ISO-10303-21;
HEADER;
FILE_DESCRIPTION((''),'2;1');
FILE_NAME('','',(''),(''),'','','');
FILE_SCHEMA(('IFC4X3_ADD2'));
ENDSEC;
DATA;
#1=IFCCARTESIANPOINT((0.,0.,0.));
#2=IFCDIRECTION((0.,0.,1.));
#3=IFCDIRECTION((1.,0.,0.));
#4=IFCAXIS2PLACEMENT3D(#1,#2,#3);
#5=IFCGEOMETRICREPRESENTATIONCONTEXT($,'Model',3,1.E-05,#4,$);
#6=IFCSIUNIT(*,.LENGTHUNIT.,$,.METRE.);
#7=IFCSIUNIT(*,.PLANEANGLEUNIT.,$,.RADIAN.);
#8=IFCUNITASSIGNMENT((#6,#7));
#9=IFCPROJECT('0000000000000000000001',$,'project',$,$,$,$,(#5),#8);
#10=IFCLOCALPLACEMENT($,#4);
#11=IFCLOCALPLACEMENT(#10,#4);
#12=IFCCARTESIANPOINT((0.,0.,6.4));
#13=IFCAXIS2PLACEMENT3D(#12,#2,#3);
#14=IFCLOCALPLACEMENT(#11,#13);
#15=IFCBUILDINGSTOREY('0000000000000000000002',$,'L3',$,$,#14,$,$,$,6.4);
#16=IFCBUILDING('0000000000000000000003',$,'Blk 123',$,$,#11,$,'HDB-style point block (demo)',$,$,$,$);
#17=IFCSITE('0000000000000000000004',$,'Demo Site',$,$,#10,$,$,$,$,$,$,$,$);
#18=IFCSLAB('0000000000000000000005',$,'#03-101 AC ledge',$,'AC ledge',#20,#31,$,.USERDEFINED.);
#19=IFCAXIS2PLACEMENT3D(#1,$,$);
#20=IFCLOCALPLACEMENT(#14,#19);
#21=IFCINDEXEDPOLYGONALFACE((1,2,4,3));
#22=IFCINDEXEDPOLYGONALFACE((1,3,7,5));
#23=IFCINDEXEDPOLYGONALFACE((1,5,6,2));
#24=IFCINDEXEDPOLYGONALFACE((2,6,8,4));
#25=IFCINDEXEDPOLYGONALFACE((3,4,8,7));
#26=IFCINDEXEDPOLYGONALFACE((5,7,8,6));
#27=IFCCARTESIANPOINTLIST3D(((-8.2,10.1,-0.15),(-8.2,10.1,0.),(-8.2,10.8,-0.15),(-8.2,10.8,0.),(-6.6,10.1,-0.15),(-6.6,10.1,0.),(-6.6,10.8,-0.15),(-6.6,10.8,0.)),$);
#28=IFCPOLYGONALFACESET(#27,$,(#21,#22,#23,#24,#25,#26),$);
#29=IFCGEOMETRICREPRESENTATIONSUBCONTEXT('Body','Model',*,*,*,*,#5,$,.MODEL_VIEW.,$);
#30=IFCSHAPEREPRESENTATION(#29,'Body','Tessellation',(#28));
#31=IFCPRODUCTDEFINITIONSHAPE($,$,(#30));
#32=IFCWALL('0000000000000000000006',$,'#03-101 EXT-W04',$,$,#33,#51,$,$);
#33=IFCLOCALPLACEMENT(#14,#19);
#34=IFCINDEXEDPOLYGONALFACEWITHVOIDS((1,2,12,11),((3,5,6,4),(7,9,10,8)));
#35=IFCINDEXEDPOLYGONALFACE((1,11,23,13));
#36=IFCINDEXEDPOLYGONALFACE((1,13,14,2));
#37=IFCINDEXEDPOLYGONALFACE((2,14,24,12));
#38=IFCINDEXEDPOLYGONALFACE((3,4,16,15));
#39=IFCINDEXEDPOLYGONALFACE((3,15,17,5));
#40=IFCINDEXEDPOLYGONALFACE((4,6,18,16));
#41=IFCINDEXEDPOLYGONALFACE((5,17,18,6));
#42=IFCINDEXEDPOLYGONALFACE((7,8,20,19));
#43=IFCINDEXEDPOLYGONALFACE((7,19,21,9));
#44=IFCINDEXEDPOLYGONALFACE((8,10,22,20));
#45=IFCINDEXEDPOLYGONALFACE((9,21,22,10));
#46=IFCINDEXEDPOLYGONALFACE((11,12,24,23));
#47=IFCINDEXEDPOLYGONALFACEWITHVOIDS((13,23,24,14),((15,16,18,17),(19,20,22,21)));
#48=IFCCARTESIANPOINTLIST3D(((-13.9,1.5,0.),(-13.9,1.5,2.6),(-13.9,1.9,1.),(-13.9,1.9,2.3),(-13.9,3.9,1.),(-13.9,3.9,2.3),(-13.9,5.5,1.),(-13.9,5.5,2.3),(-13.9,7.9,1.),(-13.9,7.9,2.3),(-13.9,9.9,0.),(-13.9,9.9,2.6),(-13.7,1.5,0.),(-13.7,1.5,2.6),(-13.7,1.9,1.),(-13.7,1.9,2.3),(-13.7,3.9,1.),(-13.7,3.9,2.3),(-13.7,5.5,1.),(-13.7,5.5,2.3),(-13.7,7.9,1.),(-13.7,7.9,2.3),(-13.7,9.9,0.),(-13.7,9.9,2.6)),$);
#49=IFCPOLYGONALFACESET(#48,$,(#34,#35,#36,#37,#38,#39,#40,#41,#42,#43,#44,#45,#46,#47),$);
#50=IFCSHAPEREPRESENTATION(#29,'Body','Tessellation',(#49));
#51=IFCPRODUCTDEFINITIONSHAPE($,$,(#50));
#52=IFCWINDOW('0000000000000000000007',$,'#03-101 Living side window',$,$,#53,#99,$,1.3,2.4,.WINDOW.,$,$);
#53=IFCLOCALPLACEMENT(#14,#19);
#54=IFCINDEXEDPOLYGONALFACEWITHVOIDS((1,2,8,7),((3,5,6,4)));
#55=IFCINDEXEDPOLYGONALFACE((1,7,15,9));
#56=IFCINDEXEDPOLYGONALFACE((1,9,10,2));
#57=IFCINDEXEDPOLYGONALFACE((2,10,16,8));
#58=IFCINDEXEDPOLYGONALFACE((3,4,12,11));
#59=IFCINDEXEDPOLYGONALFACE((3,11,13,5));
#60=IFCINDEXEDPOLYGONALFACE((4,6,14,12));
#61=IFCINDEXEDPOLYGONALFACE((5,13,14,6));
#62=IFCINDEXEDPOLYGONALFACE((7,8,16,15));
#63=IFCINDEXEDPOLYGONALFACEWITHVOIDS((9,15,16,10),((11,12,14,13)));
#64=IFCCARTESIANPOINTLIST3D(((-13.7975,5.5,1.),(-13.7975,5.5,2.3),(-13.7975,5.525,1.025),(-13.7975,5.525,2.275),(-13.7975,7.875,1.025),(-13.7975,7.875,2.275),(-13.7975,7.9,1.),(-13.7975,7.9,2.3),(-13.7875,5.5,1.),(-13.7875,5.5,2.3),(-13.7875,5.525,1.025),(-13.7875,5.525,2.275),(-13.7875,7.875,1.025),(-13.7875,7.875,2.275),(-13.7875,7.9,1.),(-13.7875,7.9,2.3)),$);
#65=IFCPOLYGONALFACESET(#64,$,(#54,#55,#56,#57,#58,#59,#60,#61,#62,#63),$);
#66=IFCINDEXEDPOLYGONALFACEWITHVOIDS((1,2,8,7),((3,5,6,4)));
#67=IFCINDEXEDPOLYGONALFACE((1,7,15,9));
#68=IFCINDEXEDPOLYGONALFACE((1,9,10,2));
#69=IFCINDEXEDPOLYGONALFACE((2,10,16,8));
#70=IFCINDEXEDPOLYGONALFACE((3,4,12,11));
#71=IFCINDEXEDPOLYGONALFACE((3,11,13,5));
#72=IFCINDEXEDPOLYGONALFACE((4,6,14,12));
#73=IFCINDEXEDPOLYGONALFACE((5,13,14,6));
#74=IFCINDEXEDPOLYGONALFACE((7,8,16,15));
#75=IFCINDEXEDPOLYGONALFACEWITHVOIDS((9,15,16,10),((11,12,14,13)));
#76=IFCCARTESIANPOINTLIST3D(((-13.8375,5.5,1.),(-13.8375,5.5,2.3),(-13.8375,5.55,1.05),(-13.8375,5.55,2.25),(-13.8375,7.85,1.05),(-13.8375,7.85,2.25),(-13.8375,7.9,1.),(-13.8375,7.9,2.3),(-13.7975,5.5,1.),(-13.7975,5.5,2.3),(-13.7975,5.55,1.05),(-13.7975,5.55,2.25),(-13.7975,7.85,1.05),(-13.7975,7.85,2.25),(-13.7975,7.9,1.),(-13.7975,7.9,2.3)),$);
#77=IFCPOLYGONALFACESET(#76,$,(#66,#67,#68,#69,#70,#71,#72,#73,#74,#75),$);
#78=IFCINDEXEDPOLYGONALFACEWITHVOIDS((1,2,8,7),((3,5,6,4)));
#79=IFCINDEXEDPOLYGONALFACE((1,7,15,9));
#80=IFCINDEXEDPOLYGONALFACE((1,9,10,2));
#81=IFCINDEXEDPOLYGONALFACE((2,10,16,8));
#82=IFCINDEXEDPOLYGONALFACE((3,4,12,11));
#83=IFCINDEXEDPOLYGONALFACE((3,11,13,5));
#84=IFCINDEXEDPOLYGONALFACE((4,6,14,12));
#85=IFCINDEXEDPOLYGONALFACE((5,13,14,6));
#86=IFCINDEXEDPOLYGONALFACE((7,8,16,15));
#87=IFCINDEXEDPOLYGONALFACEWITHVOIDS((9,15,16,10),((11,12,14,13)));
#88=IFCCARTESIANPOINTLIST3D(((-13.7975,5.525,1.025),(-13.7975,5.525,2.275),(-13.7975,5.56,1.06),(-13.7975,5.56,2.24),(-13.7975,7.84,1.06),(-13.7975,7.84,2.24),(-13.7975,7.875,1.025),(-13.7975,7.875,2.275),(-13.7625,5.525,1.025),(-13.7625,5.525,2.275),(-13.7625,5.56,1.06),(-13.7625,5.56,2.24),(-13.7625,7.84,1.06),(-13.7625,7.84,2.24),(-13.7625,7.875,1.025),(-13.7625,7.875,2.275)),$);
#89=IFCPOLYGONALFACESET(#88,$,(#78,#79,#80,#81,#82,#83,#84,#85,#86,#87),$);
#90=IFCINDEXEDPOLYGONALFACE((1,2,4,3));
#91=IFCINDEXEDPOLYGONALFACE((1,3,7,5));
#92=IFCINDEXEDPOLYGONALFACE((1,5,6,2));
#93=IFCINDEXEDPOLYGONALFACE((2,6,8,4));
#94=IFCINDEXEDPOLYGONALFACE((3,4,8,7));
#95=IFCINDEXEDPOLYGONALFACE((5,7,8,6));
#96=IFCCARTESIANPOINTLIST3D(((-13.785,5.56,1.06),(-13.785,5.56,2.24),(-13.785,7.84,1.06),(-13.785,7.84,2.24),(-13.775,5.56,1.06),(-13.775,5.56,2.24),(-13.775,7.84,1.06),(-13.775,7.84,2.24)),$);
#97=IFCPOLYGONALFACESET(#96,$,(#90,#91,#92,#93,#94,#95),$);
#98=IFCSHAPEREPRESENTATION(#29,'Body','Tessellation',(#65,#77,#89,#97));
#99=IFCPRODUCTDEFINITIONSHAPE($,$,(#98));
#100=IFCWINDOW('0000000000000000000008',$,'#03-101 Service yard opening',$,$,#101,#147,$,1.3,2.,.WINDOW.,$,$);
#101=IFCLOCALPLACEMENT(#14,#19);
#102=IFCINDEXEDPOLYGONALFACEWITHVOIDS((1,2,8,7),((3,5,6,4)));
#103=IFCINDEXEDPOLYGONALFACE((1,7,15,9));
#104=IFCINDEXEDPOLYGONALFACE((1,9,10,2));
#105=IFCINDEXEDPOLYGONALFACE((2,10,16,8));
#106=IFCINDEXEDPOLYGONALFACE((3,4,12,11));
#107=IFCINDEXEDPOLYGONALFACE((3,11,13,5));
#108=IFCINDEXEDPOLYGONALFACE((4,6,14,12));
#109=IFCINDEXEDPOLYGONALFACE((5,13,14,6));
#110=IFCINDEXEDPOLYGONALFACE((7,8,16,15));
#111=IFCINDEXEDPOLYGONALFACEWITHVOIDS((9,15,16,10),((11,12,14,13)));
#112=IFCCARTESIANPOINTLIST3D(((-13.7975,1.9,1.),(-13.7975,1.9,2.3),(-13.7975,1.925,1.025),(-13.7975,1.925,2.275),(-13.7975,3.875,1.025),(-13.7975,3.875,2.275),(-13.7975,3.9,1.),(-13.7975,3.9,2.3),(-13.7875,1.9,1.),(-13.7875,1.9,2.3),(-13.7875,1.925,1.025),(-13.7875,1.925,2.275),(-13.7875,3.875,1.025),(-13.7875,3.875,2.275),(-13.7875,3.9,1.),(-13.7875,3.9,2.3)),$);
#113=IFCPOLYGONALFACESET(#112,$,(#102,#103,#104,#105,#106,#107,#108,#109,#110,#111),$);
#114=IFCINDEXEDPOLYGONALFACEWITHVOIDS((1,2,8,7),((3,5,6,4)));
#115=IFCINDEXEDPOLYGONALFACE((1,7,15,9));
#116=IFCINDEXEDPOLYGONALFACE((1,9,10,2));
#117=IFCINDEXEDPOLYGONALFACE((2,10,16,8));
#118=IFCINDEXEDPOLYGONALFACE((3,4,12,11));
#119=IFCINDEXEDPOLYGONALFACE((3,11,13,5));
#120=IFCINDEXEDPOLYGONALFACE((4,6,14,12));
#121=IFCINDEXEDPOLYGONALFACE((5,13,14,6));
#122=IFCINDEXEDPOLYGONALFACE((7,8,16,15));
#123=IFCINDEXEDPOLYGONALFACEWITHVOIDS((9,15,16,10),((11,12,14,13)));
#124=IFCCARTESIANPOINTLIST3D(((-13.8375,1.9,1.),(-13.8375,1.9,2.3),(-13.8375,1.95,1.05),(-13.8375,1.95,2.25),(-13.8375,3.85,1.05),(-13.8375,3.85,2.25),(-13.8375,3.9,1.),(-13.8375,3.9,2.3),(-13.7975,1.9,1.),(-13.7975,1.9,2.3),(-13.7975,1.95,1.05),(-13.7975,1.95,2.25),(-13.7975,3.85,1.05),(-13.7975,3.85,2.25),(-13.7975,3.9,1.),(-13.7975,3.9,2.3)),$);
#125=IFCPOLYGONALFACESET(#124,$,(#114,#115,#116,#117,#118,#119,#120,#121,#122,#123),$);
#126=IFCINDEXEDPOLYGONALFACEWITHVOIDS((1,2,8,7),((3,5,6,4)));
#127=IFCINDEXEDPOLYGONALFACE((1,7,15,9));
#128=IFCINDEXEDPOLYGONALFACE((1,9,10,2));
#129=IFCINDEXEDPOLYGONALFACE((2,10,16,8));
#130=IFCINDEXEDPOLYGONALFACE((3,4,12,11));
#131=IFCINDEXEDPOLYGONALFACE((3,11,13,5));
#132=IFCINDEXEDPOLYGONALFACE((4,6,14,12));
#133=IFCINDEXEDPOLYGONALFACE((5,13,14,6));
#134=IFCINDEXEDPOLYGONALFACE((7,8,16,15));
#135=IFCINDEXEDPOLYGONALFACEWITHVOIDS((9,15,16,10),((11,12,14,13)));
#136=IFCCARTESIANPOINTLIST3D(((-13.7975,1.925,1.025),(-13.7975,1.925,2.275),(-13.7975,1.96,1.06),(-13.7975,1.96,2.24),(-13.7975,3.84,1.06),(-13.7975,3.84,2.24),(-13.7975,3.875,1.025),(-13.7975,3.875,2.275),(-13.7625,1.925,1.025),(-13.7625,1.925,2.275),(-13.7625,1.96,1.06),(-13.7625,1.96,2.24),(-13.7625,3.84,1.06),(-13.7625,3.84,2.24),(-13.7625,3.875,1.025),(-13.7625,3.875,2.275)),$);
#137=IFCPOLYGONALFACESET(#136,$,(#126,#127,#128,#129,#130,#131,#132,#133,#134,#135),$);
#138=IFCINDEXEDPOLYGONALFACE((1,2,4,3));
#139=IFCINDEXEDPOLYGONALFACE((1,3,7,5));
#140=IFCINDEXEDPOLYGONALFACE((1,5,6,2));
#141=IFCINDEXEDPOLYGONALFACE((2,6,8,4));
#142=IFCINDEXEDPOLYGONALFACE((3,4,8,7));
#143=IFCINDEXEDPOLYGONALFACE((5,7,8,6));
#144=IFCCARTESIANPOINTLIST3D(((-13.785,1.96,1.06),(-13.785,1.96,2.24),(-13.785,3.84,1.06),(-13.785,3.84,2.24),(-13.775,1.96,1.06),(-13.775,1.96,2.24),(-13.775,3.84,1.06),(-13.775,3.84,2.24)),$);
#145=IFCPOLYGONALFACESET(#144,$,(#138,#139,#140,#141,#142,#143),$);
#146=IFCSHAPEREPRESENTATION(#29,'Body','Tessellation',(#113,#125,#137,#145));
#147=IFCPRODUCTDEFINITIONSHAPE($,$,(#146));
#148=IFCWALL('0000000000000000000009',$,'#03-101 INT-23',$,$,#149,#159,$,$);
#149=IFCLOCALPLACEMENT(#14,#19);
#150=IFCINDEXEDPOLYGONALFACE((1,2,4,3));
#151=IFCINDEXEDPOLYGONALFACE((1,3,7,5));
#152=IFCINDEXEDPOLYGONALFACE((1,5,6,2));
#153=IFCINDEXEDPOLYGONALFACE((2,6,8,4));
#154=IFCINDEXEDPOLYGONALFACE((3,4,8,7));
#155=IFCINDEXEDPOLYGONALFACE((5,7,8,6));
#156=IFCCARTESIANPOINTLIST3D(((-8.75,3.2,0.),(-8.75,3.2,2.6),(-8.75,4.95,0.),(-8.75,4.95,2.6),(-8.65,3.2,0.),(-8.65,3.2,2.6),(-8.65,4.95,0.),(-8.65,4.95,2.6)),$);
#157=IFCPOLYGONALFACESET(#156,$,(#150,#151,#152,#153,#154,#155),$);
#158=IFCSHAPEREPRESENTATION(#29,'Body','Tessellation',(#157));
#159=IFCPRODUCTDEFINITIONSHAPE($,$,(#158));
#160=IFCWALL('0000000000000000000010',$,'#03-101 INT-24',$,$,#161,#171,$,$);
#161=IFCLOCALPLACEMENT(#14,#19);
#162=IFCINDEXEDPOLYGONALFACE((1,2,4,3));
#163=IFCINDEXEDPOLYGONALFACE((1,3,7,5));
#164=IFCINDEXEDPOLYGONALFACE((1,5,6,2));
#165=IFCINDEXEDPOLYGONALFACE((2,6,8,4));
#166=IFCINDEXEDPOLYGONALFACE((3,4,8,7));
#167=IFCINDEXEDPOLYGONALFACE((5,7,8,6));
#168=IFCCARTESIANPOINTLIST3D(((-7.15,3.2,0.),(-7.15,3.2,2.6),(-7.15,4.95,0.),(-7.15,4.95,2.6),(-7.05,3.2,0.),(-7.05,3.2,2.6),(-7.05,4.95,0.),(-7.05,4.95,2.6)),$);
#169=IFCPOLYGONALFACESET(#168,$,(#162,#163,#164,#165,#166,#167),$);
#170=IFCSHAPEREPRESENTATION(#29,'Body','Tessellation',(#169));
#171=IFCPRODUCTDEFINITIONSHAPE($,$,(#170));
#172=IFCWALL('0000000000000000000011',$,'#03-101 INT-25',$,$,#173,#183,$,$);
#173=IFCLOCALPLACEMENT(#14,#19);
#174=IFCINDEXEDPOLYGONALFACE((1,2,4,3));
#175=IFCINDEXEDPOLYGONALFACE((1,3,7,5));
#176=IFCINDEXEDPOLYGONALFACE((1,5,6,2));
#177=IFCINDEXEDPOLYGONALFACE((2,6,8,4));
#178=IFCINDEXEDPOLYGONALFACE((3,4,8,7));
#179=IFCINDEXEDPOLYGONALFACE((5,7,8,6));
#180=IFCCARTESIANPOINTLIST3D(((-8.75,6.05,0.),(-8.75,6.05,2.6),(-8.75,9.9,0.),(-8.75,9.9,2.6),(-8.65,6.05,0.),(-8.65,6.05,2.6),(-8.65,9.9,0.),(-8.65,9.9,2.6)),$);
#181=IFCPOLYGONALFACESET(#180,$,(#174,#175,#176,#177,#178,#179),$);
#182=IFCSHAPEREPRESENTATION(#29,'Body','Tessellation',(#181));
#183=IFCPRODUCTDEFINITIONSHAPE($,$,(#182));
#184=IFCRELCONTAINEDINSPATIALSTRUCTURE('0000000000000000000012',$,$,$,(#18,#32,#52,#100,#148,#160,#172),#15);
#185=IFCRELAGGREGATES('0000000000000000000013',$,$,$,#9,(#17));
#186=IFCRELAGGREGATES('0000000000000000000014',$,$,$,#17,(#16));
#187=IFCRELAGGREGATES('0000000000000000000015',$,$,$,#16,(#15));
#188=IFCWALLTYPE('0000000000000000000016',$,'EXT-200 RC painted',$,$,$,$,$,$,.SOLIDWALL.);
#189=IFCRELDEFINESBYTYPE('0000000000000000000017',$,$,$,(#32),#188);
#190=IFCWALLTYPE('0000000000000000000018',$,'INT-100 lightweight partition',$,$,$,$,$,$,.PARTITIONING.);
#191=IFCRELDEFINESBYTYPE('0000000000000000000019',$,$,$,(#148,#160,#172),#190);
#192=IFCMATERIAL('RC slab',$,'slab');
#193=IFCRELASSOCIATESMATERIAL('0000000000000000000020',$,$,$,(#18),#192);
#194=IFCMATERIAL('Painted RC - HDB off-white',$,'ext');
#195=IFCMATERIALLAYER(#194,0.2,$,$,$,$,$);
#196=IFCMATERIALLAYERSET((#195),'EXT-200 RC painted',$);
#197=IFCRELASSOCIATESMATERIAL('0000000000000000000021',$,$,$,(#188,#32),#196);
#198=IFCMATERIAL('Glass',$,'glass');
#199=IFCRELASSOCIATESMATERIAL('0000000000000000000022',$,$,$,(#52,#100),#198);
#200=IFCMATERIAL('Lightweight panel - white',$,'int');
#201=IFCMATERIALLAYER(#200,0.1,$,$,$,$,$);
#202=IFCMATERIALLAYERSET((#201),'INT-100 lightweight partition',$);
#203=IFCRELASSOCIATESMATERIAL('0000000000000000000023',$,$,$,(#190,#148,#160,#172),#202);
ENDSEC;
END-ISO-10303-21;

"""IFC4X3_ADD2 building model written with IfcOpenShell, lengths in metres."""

from ifc_helpers import new_model, si_unit, frame, origin, origin_with_axes, place, context, subcontext, project, spatial, polyline, line, indexed_curve, outline, extrude, material, layer, layer_set, layer_usage, type_object, element, fill, save


model = new_model("IFC4X3_ADD2")

# Units and contexts
model_context = context("Model", 3, precision=1e-05, world=origin_with_axes())
body_context = subcontext(model_context, "Body", "Model", "MODEL_VIEW")
ifc_project = project(units=[si_unit("LENGTHUNIT", "METRE"), si_unit("PLANEANGLEUNIT", "RADIAN")], contexts=[model_context])

# Site, building, storey
site_placement = place(None, origin_with_axes())
site = spatial("IfcSite", under=ifc_project, at=site_placement, Name="Demo Site")
building_placement = place(site_placement, origin_with_axes())
building = spatial("IfcBuilding", under=site, at=building_placement, Name="Blk 123", LongName="HDB-style point block (demo)")
storey_placement = place(building_placement, frame((0.0, 0.0, 6.4), z_axis=(0.0, 0.0, 1.0), x_axis=(1.0, 0.0, 0.0)))
storey = spatial("IfcBuildingStorey", under=building, at=storey_placement, Name="L3", Elevation=6.4)

# Slab
ifc_material_1 = material(Name="RC slab", Category="slab")
slab_placement = place(storey_placement, frame((-7.4, 10.45, -0.15), z_axis=(0.0, 0.0, 1.0), x_axis=(1.0, 0.0, 0.0)))
element("IfcSlab", 1, at=slab_placement, inside=storey, material=ifc_material_1, Name="#03-101 AC ledge", ObjectType="AC ledge", PredefinedType="USERDEFINED", context=body_context, shape_type="SweptSolid", body=[
    extrude(outline(polyline([(-0.8, -0.35), (0.8, -0.35), (0.8, 0.35), (-0.8, 0.35), (-0.8, -0.35)])), origin(), (0.0, 0.0, 1.0), 0.15),
])

# Shared definitions
ifc_material_2 = material(Name="Painted RC - HDB off-white", Category="ext")
ifc_layer_1 = layer(ifc_material_2, 0.2)
ifc_layer_set_1 = layer_set([ifc_layer_1], Name="EXT-200 RC painted")
ifc_layer_usage_1 = layer_usage(ifc_layer_set_1, "AXIS2", "POSITIVE", 0.0)
wall_type_1 = type_object("IfcWallType", Name="EXT-200 RC painted", PredefinedType="SOLIDWALL", material=ifc_layer_set_1)
ifc_material_3 = material(Name="Glass", Category="glass")

# Wall, openings, windows
wall_1_placement = place(storey_placement, frame((-13.9, 9.9, 0.0), z_axis=(0.0, 0.0, 1.0), x_axis=(0.0, -1.0, 0.0)))
wall_1 = element("IfcWall", 2, at=wall_1_placement, inside=storey, type_object=wall_type_1, material=ifc_layer_usage_1, Name="#03-101 EXT-W04", context=body_context, shape_type="SweptSolid", body=[
    extrude(outline(indexed_curve([(0.0, 0.0), (0.0, 0.2), (8.4, 0.2), (8.4, 0.0), (0.0, 0.0)], self_intersect=False)), origin_with_axes(), (0.0, 0.0, 1.0), 2.6),
])
opening_1_placement = place(wall_1_placement, frame((2.0, -0.1, 1.0), z_axis=(0.0, 0.0, 1.0), x_axis=(1.0, 0.0, 0.0)))
opening_1 = element("IfcOpeningElement", 3, at=opening_1_placement, cuts=wall_1, context=body_context, shape_type="SweptSolid", body=[
    extrude(outline(indexed_curve([(0.0, 0.0), (0.0, 0.4), (2.4, 0.4), (2.4, 0.0), (0.0, 0.0)], self_intersect=False)), origin_with_axes(), (0.0, 0.0, 1.0), 1.3),
])
opening_2_placement = place(wall_1_placement, frame((6.0, -0.1, 1.0), z_axis=(0.0, 0.0, 1.0), x_axis=(1.0, 0.0, 0.0)))
opening_2 = element("IfcOpeningElement", 4, at=opening_2_placement, cuts=wall_1, context=body_context, shape_type="SweptSolid", body=[
    extrude(outline(indexed_curve([(0.0, 0.0), (0.0, 0.4), (2.0, 0.4), (2.0, 0.0), (0.0, 0.0)], self_intersect=False)), origin_with_axes(), (0.0, 0.0, 1.0), 1.3),
])
window_1_placement = place(opening_1_placement, frame((0.0, 0.1125, 0.0), z_axis=(0.0, 0.0, 1.0), x_axis=(1.0, 0.0, 0.0)))
window_1 = element("IfcWindow", 5, at=window_1_placement, inside=storey, material=ifc_material_3, Name="#03-101 Living side window", OverallHeight=1.3, OverallWidth=2.4, PredefinedType="WINDOW", context=body_context, shape_type="SweptSolid", body=[
    extrude(outline(indexed_curve([(0.0, 0.0), (2.4, 0.0), (2.4, 1.3), (0.0, 1.3)], segments=[line(1, 2, 3, 4, 1)]), holes=[indexed_curve([(0.025, 0.025), (2.375, 0.025), (2.375, 1.275), (0.025, 1.275)], segments=[line(1, 2, 3, 4, 1)])]), frame((0.0, 0.09, 0.0), z_axis=(0.0, -1.0, 0.0), x_axis=(1.0, 0.0, 0.0)), (0.0, 0.0, -1.0), 0.01),
    extrude(outline(indexed_curve([(0.0, 0.0), (2.4, 0.0), (2.4, 1.3), (0.0, 1.3)], segments=[line(1, 2, 3, 4, 1)]), holes=[indexed_curve([(0.05, 0.05), (2.35, 0.05), (2.35, 1.25), (0.05, 1.25)], segments=[line(1, 2, 3, 4, 1)])]), frame((0.0, 0.05, 0.0), z_axis=(0.0, -1.0, 0.0), x_axis=(1.0, 0.0, 0.0)), (0.0, 0.0, -1.0), 0.04),
    extrude(outline(indexed_curve([(0.0, 0.0), (2.35, 0.0), (2.35, 1.25), (0.0, 1.25)], segments=[line(1, 2, 3, 4, 1)]), holes=[indexed_curve([(0.035, 0.035), (2.315, 0.035), (2.315, 1.215), (0.035, 1.215)], segments=[line(1, 2, 3, 4, 1)])]), frame((0.025, 0.09, 0.025), z_axis=(0.0, -1.0, 0.0), x_axis=(1.0, 0.0, 0.0)), (0.0, 0.0, -1.0), 0.035),
    extrude(outline(indexed_curve([(0.035, 0.035), (2.315, 0.035), (2.315, 1.215), (0.035, 1.215)], segments=[line(1, 2, 3, 4, 1)])), frame((0.025, 0.1025, 0.025), z_axis=(0.0, -1.0, 0.0), x_axis=(1.0, 0.0, 0.0)), (0.0, 0.0, -1.0), 0.01),
])
fill(opening_1, window_1)
window_2_placement = place(opening_2_placement, frame((0.0, 0.1125, 0.0), z_axis=(0.0, 0.0, 1.0), x_axis=(1.0, 0.0, 0.0)))
window_2 = element("IfcWindow", 6, at=window_2_placement, inside=storey, material=ifc_material_3, Name="#03-101 Service yard opening", OverallHeight=1.3, OverallWidth=2.0, PredefinedType="WINDOW", context=body_context, shape_type="SweptSolid", body=[
    extrude(outline(indexed_curve([(0.0, 0.0), (2.0, 0.0), (2.0, 1.3), (0.0, 1.3)], segments=[line(1, 2, 3, 4, 1)]), holes=[indexed_curve([(0.025, 0.025), (1.975, 0.025), (1.975, 1.275), (0.025, 1.275)], segments=[line(1, 2, 3, 4, 1)])]), frame((0.0, 0.09, 0.0), z_axis=(0.0, -1.0, 0.0), x_axis=(1.0, 0.0, 0.0)), (0.0, 0.0, -1.0), 0.01),
    extrude(outline(indexed_curve([(0.0, 0.0), (2.0, 0.0), (2.0, 1.3), (0.0, 1.3)], segments=[line(1, 2, 3, 4, 1)]), holes=[indexed_curve([(0.05, 0.05), (1.95, 0.05), (1.95, 1.25), (0.05, 1.25)], segments=[line(1, 2, 3, 4, 1)])]), frame((0.0, 0.05, 0.0), z_axis=(0.0, -1.0, 0.0), x_axis=(1.0, 0.0, 0.0)), (0.0, 0.0, -1.0), 0.04),
    extrude(outline(indexed_curve([(0.0, 0.0), (1.95, 0.0), (1.95, 1.25), (0.0, 1.25)], segments=[line(1, 2, 3, 4, 1)]), holes=[indexed_curve([(0.035, 0.035), (1.915, 0.035), (1.915, 1.215), (0.035, 1.215)], segments=[line(1, 2, 3, 4, 1)])]), frame((0.025, 0.09, 0.025), z_axis=(0.0, -1.0, 0.0), x_axis=(1.0, 0.0, 0.0)), (0.0, 0.0, -1.0), 0.035),
    extrude(outline(indexed_curve([(0.035, 0.035), (1.915, 0.035), (1.915, 1.215), (0.035, 1.215)], segments=[line(1, 2, 3, 4, 1)])), frame((0.025, 0.1025, 0.025), z_axis=(0.0, -1.0, 0.0), x_axis=(1.0, 0.0, 0.0)), (0.0, 0.0, -1.0), 0.01),
])
fill(opening_2, window_2)

# Walls
ifc_material_4 = material(Name="Lightweight panel - white", Category="int")
ifc_layer_2 = layer(ifc_material_4, 0.1)
ifc_layer_set_2 = layer_set([ifc_layer_2], Name="INT-100 lightweight partition")
ifc_layer_usage_2 = layer_usage(ifc_layer_set_2, "AXIS2", "POSITIVE", -0.05)
wall_type_2 = type_object("IfcWallType", Name="INT-100 lightweight partition", PredefinedType="PARTITIONING", material=ifc_layer_set_2)
for number, where, z_axis, x_axis, name in (
    (7, (-8.7, 3.2, 0.0), (0.0, 0.0, 1.0), (0.0, 1.0, 0.0), "#03-101 INT-23"),
    (8, (-7.1, 3.2, 0.0), (0.0, 0.0, 1.0), (0.0, 1.0, 0.0), "#03-101 INT-24"),
):
    element("IfcWall", number, at=place(storey_placement, frame(where, z_axis=z_axis, x_axis=x_axis)), inside=storey, type_object=wall_type_2, material=ifc_layer_usage_2, Name=name, context=body_context, shape_type="SweptSolid", body=[
        extrude(outline(indexed_curve([(0.0, 0.0), (0.0, 0.1), (1.75, 0.1), (1.75, 0.0), (0.0, 0.0)], self_intersect=False)), frame((0.0, -0.05, 0.0), z_axis=(0.0, 0.0, 1.0), x_axis=(1.0, 0.0, 0.0)), (0.0, 0.0, 1.0), 2.6),
    ])
wall_2_placement = place(storey_placement, frame((-8.7, 6.05, 0.0), z_axis=(0.0, 0.0, 1.0), x_axis=(0.0, 1.0, 0.0)))
element("IfcWall", 9, at=wall_2_placement, inside=storey, type_object=wall_type_2, material=ifc_layer_usage_2, Name="#03-101 INT-25", context=body_context, shape_type="SweptSolid", body=[
    extrude(outline(indexed_curve([(0.0, 0.0), (0.0, 0.1), (3.85, 0.1), (3.85, 0.0), (0.0, 0.0)], self_intersect=False)), frame((0.0, -0.05, 0.0), z_axis=(0.0, 0.0, 1.0), x_axis=(1.0, 0.0, 0.0)), (0.0, 0.0, 1.0), 2.6),
])

save(model, "model.ifc")
